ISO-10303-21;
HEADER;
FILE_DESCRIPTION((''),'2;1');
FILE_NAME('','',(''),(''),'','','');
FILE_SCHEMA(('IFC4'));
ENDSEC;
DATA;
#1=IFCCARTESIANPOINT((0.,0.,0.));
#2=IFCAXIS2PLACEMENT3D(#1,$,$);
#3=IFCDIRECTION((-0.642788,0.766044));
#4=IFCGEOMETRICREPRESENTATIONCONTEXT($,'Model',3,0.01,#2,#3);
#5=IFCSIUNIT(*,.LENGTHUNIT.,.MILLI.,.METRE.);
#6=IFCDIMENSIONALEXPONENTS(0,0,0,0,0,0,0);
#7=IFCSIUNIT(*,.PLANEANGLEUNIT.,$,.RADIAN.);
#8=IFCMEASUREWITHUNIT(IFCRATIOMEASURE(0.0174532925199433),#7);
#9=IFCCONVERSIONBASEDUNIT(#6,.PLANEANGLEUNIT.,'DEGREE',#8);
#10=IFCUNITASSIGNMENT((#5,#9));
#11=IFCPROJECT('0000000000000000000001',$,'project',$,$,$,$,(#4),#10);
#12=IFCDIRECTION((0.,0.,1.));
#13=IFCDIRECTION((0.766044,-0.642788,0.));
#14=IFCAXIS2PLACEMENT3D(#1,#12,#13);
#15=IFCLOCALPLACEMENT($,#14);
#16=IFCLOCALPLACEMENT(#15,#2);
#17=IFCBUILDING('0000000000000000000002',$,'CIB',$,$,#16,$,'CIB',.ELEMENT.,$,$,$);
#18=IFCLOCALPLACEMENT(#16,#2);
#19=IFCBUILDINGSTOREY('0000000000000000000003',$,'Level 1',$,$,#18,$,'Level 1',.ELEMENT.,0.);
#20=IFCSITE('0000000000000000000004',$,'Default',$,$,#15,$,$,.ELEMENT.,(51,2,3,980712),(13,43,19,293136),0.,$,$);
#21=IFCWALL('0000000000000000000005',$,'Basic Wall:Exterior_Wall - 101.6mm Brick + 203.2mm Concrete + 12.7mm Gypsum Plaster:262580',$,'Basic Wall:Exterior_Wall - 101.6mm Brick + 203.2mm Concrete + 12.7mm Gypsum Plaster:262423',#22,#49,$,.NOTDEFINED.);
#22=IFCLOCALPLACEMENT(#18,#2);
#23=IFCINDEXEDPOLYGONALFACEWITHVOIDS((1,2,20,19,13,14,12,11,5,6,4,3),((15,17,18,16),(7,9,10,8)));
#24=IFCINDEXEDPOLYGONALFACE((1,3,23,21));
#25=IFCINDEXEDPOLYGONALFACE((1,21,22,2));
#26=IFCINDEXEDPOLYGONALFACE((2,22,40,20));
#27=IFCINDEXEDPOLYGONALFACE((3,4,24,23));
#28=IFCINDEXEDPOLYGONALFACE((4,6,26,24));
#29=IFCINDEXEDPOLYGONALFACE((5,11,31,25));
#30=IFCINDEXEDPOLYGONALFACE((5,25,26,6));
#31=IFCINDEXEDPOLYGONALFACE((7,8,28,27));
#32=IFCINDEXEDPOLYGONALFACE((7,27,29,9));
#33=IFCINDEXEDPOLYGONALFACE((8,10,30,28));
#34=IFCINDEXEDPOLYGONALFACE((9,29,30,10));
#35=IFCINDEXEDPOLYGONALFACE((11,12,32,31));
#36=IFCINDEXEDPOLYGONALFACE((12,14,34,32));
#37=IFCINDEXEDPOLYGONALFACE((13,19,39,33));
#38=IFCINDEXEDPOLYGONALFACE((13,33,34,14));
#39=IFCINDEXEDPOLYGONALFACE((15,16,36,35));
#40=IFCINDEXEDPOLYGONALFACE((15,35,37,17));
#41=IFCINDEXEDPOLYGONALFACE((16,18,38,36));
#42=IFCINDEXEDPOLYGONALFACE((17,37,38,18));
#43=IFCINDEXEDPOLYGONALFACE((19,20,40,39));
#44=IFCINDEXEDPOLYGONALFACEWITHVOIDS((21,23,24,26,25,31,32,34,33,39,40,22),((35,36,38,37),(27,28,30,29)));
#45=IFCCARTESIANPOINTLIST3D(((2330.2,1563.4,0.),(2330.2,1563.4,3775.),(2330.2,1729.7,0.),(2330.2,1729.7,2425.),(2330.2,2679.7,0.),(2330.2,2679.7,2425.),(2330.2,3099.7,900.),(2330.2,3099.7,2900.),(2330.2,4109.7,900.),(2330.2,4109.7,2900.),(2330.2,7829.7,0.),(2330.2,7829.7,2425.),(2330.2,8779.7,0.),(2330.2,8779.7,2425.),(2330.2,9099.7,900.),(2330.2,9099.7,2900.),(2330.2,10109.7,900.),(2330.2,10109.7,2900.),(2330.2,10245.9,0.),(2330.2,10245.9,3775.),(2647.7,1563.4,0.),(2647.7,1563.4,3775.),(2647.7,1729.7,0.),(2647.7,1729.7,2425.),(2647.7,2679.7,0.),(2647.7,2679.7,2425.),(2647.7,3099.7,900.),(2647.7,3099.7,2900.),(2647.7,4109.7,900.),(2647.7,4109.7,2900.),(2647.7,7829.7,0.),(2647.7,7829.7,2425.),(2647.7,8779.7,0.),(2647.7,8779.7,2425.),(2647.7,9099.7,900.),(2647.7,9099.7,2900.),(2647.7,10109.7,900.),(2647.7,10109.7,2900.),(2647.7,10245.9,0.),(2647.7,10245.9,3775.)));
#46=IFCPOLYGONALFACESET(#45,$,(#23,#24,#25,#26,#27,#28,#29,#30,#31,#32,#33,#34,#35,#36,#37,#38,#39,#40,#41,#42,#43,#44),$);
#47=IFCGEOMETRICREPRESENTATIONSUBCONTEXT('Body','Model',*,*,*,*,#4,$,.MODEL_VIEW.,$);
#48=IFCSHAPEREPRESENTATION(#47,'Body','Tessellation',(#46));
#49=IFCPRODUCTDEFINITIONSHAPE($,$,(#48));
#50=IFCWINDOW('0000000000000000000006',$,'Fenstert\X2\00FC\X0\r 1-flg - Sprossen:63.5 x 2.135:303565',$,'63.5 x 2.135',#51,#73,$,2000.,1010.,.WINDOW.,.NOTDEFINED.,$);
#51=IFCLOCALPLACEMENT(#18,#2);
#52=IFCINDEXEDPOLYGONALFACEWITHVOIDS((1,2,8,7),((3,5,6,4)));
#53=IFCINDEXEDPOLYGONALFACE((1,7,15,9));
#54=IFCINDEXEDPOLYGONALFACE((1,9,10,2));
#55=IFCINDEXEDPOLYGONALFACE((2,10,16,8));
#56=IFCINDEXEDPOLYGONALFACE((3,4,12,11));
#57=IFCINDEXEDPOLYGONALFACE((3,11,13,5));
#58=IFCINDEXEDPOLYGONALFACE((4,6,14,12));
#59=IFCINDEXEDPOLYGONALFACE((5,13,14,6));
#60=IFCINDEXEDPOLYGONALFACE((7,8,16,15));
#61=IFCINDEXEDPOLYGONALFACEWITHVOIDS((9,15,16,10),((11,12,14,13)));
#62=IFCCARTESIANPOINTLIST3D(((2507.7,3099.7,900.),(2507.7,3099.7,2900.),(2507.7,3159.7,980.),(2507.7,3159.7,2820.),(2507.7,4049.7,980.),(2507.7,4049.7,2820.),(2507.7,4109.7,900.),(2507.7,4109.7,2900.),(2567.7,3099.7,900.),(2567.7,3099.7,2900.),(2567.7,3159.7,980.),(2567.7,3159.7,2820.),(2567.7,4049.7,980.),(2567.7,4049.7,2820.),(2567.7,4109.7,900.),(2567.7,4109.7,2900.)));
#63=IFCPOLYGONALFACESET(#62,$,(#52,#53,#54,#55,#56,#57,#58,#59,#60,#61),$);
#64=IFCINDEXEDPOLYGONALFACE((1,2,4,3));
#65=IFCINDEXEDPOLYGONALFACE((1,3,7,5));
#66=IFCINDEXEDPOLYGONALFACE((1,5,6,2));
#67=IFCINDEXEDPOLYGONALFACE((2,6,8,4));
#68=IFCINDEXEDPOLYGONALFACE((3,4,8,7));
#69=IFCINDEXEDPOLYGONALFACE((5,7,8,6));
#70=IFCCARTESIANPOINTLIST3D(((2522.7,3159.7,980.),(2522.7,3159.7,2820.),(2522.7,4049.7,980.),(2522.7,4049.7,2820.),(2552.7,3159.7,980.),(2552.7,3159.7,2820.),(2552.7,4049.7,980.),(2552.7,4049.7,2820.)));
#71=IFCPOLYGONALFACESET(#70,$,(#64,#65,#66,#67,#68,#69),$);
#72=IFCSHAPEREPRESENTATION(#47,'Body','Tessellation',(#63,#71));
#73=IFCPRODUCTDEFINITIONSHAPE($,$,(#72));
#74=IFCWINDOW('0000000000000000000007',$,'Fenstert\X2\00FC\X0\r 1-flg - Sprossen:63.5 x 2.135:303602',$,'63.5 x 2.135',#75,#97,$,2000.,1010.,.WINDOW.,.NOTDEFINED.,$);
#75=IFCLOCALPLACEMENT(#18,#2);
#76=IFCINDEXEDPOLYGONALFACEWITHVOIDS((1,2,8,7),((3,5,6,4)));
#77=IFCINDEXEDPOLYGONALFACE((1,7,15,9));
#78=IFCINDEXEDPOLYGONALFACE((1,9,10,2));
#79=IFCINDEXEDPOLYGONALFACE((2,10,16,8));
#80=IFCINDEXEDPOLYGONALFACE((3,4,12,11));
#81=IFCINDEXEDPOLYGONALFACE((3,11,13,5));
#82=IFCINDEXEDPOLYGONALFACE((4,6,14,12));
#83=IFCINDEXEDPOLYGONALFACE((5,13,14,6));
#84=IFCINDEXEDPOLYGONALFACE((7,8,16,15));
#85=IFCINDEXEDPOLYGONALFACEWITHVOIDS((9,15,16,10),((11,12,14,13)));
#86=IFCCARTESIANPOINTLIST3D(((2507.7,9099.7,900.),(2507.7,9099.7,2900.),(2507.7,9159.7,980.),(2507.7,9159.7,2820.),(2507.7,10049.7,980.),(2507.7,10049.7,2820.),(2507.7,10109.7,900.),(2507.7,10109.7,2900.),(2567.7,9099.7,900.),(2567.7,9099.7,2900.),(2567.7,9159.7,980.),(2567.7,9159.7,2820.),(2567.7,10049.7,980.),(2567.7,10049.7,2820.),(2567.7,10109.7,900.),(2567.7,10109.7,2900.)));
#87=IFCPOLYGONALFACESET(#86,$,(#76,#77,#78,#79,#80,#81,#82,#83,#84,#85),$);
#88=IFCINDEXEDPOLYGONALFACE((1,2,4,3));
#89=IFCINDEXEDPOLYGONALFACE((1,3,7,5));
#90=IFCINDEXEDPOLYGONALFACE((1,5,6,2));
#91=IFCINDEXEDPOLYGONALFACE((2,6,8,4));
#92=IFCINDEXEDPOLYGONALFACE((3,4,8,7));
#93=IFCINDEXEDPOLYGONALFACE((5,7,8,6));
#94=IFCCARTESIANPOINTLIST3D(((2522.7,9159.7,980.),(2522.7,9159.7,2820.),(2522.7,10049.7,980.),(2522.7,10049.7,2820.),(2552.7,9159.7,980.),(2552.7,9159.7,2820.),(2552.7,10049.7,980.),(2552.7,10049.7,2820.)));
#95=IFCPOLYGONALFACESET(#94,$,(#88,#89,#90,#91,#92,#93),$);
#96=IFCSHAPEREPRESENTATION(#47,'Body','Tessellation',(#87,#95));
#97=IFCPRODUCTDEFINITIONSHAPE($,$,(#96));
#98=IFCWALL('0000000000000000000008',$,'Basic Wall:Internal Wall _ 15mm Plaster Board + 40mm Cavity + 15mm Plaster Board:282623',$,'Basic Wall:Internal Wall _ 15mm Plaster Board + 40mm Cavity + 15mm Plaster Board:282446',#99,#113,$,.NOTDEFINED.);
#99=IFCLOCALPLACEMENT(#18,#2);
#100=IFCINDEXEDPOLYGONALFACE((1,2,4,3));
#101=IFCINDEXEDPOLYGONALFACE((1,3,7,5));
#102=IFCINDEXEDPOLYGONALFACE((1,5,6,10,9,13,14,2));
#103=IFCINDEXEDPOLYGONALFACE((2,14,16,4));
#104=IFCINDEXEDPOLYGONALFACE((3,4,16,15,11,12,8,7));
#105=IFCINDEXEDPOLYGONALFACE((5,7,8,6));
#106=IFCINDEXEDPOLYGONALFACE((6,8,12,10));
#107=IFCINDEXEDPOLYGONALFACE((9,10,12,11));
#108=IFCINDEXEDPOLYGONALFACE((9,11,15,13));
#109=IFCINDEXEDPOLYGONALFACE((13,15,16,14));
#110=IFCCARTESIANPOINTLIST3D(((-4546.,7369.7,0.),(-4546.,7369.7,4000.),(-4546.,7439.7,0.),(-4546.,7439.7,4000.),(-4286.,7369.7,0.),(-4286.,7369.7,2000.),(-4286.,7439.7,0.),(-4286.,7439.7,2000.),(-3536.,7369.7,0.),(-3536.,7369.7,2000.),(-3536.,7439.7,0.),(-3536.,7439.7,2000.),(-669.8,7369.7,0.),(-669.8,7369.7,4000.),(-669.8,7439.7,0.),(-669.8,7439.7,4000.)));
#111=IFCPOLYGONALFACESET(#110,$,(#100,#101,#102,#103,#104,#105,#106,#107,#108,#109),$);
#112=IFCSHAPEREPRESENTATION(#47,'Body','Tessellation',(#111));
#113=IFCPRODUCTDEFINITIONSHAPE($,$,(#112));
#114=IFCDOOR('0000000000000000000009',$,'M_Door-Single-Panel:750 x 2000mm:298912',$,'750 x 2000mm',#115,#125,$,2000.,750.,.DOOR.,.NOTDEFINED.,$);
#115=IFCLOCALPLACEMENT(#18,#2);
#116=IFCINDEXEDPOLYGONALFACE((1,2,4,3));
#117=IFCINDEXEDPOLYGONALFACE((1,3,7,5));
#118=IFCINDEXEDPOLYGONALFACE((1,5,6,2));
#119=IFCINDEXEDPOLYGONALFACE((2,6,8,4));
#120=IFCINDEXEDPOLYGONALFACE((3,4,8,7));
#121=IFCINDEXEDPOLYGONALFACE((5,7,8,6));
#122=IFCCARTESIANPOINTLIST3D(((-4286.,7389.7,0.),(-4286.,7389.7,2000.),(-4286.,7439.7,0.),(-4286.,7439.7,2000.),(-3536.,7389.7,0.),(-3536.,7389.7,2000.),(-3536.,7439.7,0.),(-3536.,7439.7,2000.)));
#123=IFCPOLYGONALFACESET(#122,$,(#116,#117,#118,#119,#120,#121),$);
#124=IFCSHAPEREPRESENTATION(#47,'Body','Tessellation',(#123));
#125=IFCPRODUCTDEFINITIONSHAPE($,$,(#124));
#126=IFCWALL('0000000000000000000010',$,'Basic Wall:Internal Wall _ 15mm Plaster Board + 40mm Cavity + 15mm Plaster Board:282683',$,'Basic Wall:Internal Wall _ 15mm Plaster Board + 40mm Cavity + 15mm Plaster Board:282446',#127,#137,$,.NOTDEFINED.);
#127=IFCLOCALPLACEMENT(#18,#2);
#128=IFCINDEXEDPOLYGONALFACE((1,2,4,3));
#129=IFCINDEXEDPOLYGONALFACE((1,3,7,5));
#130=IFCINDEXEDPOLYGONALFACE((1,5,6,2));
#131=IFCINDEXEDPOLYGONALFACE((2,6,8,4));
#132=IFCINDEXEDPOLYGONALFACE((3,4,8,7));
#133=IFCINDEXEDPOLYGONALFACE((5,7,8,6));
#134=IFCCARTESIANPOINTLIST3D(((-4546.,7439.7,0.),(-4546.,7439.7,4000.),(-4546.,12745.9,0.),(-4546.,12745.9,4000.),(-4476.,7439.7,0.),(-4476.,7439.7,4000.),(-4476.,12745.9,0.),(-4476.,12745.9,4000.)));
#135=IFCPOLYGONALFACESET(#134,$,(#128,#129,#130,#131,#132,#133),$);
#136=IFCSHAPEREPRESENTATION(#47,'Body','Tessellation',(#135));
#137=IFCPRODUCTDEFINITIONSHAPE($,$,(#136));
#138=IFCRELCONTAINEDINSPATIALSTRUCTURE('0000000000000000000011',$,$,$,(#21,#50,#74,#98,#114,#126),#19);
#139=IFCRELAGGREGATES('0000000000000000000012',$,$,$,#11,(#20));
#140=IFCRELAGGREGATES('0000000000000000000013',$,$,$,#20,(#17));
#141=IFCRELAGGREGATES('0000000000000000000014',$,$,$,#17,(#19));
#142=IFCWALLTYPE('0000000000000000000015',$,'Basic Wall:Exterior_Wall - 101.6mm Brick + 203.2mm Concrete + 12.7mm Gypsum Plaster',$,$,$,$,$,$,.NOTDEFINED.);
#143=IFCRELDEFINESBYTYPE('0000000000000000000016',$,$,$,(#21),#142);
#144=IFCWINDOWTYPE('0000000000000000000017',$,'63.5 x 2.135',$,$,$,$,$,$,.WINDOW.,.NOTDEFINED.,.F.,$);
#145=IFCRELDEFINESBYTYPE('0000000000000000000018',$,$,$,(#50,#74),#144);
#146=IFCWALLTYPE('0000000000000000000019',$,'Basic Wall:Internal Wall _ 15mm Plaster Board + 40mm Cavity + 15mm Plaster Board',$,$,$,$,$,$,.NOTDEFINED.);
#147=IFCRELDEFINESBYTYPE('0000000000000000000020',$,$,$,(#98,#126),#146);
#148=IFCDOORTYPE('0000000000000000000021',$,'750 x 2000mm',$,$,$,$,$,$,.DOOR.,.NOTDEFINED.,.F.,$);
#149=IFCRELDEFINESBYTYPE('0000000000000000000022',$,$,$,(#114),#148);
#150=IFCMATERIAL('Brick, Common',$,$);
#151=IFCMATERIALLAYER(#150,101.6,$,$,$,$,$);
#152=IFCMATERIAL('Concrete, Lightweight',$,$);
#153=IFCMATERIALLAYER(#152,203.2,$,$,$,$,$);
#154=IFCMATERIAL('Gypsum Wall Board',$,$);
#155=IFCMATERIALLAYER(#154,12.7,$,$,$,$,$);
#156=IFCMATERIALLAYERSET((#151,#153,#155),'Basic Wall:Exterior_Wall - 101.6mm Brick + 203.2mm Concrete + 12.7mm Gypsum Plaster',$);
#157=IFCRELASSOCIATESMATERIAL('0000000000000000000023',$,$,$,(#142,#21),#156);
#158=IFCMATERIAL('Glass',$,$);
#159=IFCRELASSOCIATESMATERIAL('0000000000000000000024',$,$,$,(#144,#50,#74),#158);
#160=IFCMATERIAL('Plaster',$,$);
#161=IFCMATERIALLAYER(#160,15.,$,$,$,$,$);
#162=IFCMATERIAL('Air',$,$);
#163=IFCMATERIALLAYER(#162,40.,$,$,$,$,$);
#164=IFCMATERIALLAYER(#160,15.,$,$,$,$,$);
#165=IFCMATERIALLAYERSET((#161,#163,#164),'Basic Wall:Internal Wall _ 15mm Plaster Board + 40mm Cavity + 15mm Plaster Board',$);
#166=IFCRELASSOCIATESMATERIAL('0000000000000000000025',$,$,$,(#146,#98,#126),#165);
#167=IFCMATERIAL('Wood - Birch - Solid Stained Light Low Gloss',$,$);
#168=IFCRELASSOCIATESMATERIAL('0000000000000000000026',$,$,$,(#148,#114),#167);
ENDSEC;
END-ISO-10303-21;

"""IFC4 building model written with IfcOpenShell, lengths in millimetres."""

from ifc_helpers import new_model, entity, si_unit, converted_unit, direction, frame, frame_2d, origin, origin_2d_with_axis, place, context, subcontext, project, spatial, polyline, rectangle, outline, extrude, clip, bounded_halfspace, source, transform, mapped, material, layer, layer_set, layer_usage, type_object, type_shapes, element, fill, save


model = new_model("IFC4")

# Units and contexts
model_context = context("Model", 3, precision=0.01, world=origin(), true_north=direction((-0.642788, 0.766044)))
body_context = subcontext(model_context, "Body", "Model", "MODEL_VIEW")
ifc_project = project(units=[si_unit("LENGTHUNIT", "METRE", prefix="MILLI"), converted_unit("PLANEANGLEUNIT", "DEGREE", entity("IfcRatioMeasure", 0.0174532925199433), si_unit("PLANEANGLEUNIT", "RADIAN"), dimensions=[0, 0, 0, 0, 0, 0, 0])], contexts=[model_context])

# Site, building, storey
site_placement = place(None, frame((0.0, 0.0, 0.0), z_axis=(0.0, 0.0, 1.0), x_axis=(0.766044, -0.642788, 0.0)))
site = spatial("IfcSite", under=ifc_project, at=site_placement, Name="Default", CompositionType="ELEMENT", RefLatitude=(51, 2, 3, 980712), RefLongitude=(13, 43, 19, 293136), RefElevation=0.0)
building_placement = place(site_placement, origin())
building = spatial("IfcBuilding", under=site, at=building_placement, Name="CIB", LongName="CIB", CompositionType="ELEMENT")
storey_placement = place(building_placement, origin())
storey = spatial("IfcBuildingStorey", under=building, at=storey_placement, Name="Level 1", LongName="Level 1", CompositionType="ELEMENT", Elevation=0.0)

# Shared definitions
ifc_material_1 = material(Name="Brick, Common")
ifc_layer_1 = layer(ifc_material_1, 101.6)
ifc_material_2 = material(Name="Concrete, Lightweight")
ifc_layer_2 = layer(ifc_material_2, 203.2)
ifc_material_3 = material(Name="Gypsum Wall Board")
ifc_layer_3 = layer(ifc_material_3, 12.7)
ifc_layer_set_1 = layer_set([ifc_layer_1, ifc_layer_2, ifc_layer_3], Name="Basic Wall:Exterior_Wall - 101.6mm Brick + 203.2mm Concrete + 12.7mm Gypsum Plaster")
wall_type_1 = type_object("IfcWallType", Name="Basic Wall:Exterior_Wall - 101.6mm Brick + 203.2mm Concrete + 12.7mm Gypsum Plaster", PredefinedType="NOTDEFINED", material=ifc_layer_set_1)
ifc_material_4 = material(Name="Glass")

# Wall, openings, windows
ifc_layer_usage_1 = layer_usage(ifc_layer_set_1, "AXIS2", "NEGATIVE", 158.8)
wall_1_placement = place(storey_placement, frame((2489.0, 10245.9, 0.0), z_axis=(0.0, 0.0, 1.0), x_axis=(0.0, -1.0, 0.0)))
wall_1 = element("IfcWall", 1, at=wall_1_placement, inside=storey, type_object=wall_type_1, material=ifc_layer_usage_1, Name="Basic Wall:Exterior_Wall - 101.6mm Brick + 203.2mm Concrete + 12.7mm Gypsum Plaster:262580", ObjectType="Basic Wall:Exterior_Wall - 101.6mm Brick + 203.2mm Concrete + 12.7mm Gypsum Plaster:262423", PredefinedType="NOTDEFINED", context=body_context, shape_type="Clipping", body=[
    clip(clip(extrude(rectangle(XDim=8682.5, YDim=317.5, at=frame_2d((4341.2, 0.0), x_axis=(-1.0, 0.0))), origin(), (0.0, 0.0, 1.0), 3775.0), bounded_halfspace(frame((0.0, -158.8, 3775.0), z_axis=(0.0, 0.0, -1.0), x_axis=(0.0, 1.0, 0.0)), True, frame((0.0, -158.8, 3775.0)), polyline([(0.0, 0.0), (2682.5, 0.0), (3000.0, 0.0), (3000.0, 317.5), (0.0, 317.5), (0.0, 0.0)]))), bounded_halfspace(frame((5682.5, -158.8, 3775.0), z_axis=(0.0, 0.0, -1.0), x_axis=(0.0, 1.0, 0.0)), True, frame((5682.5, -158.8, 3775.0)), polyline([(0.0, 0.0), (317.5, 0.0), (3000.0, 0.0), (3000.0, 317.5), (0.0, 317.5), (0.0, 0.0)]))),
])
opening_1_placement = place(wall_1_placement, frame((2416.2, 158.7, 0.0)))
element("IfcOpeningElement", 2, at=opening_1_placement, cuts=wall_1, ObjectType="Opening", PredefinedType="OPENING", context=body_context, shape_type="SweptSolid", body=[
    extrude(rectangle(XDim=2425.0, YDim=950.0, at=frame_2d((1212.5, 475.0), x_axis=(1.0, 0.0))), frame((0.0, 0.0, 0.0), z_axis=(0.0, -1.0, 0.0), x_axis=(0.0, 0.0, 1.0)), (0.0, 0.0, 1.0), 317.5),
])
opening_2_placement = place(wall_1_placement, frame((8516.2, 158.7, 0.0)))
element("IfcOpeningElement", 3, at=opening_2_placement, cuts=wall_1, ObjectType="Opening", PredefinedType="OPENING", context=body_context, shape_type="SweptSolid", body=[
    extrude(rectangle(XDim=2425.0, YDim=950.0, at=frame_2d((1212.5, 475.0), x_axis=(1.0, 0.0))), frame((0.0, 0.0, 0.0), z_axis=(0.0, -1.0, 0.0), x_axis=(0.0, 0.0, 1.0)), (0.0, 0.0, 1.0), 317.5),
])
opening_3_placement = place(wall_1_placement, frame((7146.2, 158.8, 900.0)))
opening_3 = element("IfcOpeningElement", 4, at=opening_3_placement, cuts=wall_1, ObjectType="Opening", PredefinedType="OPENING", context=body_context, shape_type="SweptSolid", body=[
    extrude(rectangle(XDim=2000.0, YDim=1010.0, at=frame_2d((1000.0, 505.0), x_axis=(1.0, 0.0))), frame((0.0, 0.0, 0.0), z_axis=(0.0, -1.0, 0.0), x_axis=(0.0, 0.0, 1.0)), (0.0, 0.0, 1.0), 317.5),
])
opening_4_placement = place(wall_1_placement, frame((1146.3, 158.8, 900.0)))
opening_4 = element("IfcOpeningElement", 5, at=opening_4_placement, cuts=wall_1, ObjectType="Opening", PredefinedType="OPENING", context=body_context, shape_type="SweptSolid", body=[
    extrude(rectangle(XDim=2000.0, YDim=1010.0, at=frame_2d((1000.0, 505.0), x_axis=(1.0, 0.0))), frame((0.0, 0.0, 0.0), z_axis=(0.0, -1.0, 0.0), x_axis=(0.0, 0.0, 1.0)), (0.0, 0.0, 1.0), 317.5),
])
window_type_1 = type_object("IfcWindowType", Name="63.5 x 2.135", ParameterTakesPrecedence=False, PartitioningType="NOTDEFINED", PredefinedType="WINDOW", material=ifc_material_4)
shared_shape_1 = source(origin(), body_context, "Body", "SweptSolid", [
    extrude(outline(polyline([(-1000.0, -505.0), (1000.0, -505.0), (1000.0, 505.0), (-1000.0, 505.0), (-1000.0, -505.0)]), holes=[polyline([(-920.0, -445.0), (-920.0, 445.0), (920.0, 445.0), (920.0, -445.0), (-920.0, -445.0)])]), frame((505.0, 177.5, 1000.0), z_axis=(0.0, 1.0, 0.0), x_axis=(0.0, 0.0, -1.0)), (0.0, 0.0, 1.0), 60.0),
    extrude(rectangle(XDim=30.0, YDim=890.0, at=origin_2d_with_axis()), frame((505.0, 207.5, 80.0), z_axis=(0.0, 0.0, 1.0), x_axis=(0.0, 1.0, 0.0)), (0.0, 0.0, 1.0), 1840.0),
])
type_shapes(window_type_1, [shared_shape_1])
window_1_placement = place(opening_3_placement, frame((-1010.0, -317.5, 0.0)))
window_1 = element("IfcWindow", 6, at=window_1_placement, inside=storey, type_object=window_type_1, material=ifc_material_4, Name="Fenstertür 1-flg - Sprossen:63.5 x 2.135:303565", ObjectType="63.5 x 2.135", OverallHeight=2000.0, OverallWidth=1010.0, PartitioningType="NOTDEFINED", PredefinedType="WINDOW", context=body_context, shape_type="MappedRepresentation", body=[
    mapped(shared_shape_1, transform((0.0, 0.0, 0.0), scale=1.0)),
])
fill(opening_3, window_1)
window_2_placement = place(opening_4_placement, frame((-1010.0, -317.5, 0.0)))
window_2 = element("IfcWindow", 7, at=window_2_placement, inside=storey, type_object=window_type_1, material=ifc_material_4, Name="Fenstertür 1-flg - Sprossen:63.5 x 2.135:303602", ObjectType="63.5 x 2.135", OverallHeight=2000.0, OverallWidth=1010.0, PartitioningType="NOTDEFINED", PredefinedType="WINDOW", context=body_context, shape_type="MappedRepresentation", body=[
    mapped(shared_shape_1, transform((0.0, 0.0, 0.0), scale=1.0)),
])
fill(opening_4, window_2)

# Wall, opening, door
ifc_material_5 = material(Name="Plaster")
ifc_layer_4 = layer(ifc_material_5, 15.0)
ifc_material_6 = material(Name="Air")
ifc_layer_5 = layer(ifc_material_6, 40.0)
ifc_layer_6 = layer(ifc_material_5, 15.0)
ifc_layer_set_2 = layer_set([ifc_layer_4, ifc_layer_5, ifc_layer_6], Name="Basic Wall:Internal Wall _ 15mm Plaster Board + 40mm Cavity + 15mm Plaster Board")
ifc_layer_usage_2 = layer_usage(ifc_layer_set_2, "AXIS2", "NEGATIVE", 35.0)
wall_type_2 = type_object("IfcWallType", Name="Basic Wall:Internal Wall _ 15mm Plaster Board + 40mm Cavity + 15mm Plaster Board", PredefinedType="NOTDEFINED", material=ifc_layer_set_2)
wall_2_placement = place(storey_placement, frame((-669.8, 7404.7, 0.0), z_axis=(0.0, 0.0, 1.0), x_axis=(-1.0, 0.0, 0.0)))
wall_2 = element("IfcWall", 8, at=wall_2_placement, inside=storey, type_object=wall_type_2, material=ifc_layer_usage_2, Name="Basic Wall:Internal Wall _ 15mm Plaster Board + 40mm Cavity + 15mm Plaster Board:282623", ObjectType="Basic Wall:Internal Wall _ 15mm Plaster Board + 40mm Cavity + 15mm Plaster Board:282446", PredefinedType="NOTDEFINED", context=body_context, shape_type="SweptSolid", body=[
    extrude(rectangle(XDim=3876.2, YDim=70.0, at=frame_2d((1938.1, 0.0), x_axis=(-1.0, 0.0))), origin(), (0.0, 0.0, 1.0), 4000.0),
])
opening_5_placement = place(wall_2_placement, frame((3616.2, 35.0, 0.0)))
opening_5 = element("IfcOpeningElement", 9, at=opening_5_placement, cuts=wall_2, ObjectType="Opening", PredefinedType="OPENING", context=body_context, shape_type="SweptSolid", body=[
    extrude(rectangle(XDim=750.0, YDim=2000.0, at=frame_2d((1000.0, 375.0), x_axis=(0.0, -1.0))), frame((0.0, 0.0, 0.0), z_axis=(0.0, -1.0, 0.0), x_axis=(0.0, 0.0, 1.0)), (0.0, 0.0, 1.0), 70.0),
])
ifc_material_7 = material(Name="Wood - Birch - Solid Stained Light Low Gloss")
door_type_1 = type_object("IfcDoorType", Name="750 x 2000mm", OperationType="NOTDEFINED", ParameterTakesPrecedence=False, PredefinedType="DOOR", material=ifc_material_7)
shared_shape_2 = source(origin(), body_context, "Body", "SweptSolid", [
    extrude(rectangle(XDim=750.0, YDim=50.0, at=origin_2d_with_axis()), frame((375.0, 45.0, 0.0)), (0.0, 0.0, 1.0), 2000.0),
])
type_shapes(door_type_1, [shared_shape_2])
door_1_placement = place(opening_5_placement, frame((0.0, 0.0, 0.0), z_axis=(0.0, 0.0, 1.0), x_axis=(-1.0, 0.0, 0.0)))
door_1 = element("IfcDoor", 10, at=door_1_placement, inside=storey, type_object=door_type_1, material=ifc_material_7, Name="M_Door-Single-Panel:750 x 2000mm:298912", ObjectType="750 x 2000mm", OperationType="NOTDEFINED", OverallHeight=2000.0, OverallWidth=750.0, PredefinedType="DOOR", context=body_context, shape_type="MappedRepresentation", body=[
    mapped(shared_shape_2, transform((0.0, 0.0, 0.0), scale=1.0)),
])
fill(opening_5, door_1)

# Wall
ifc_layer_usage_3 = layer_usage(ifc_layer_set_2, "AXIS2", "NEGATIVE", 35.0)
wall_3_placement = place(storey_placement, frame((-4511.0, 7439.7, 0.0), z_axis=(0.0, 0.0, 1.0), x_axis=(0.0, 1.0, 0.0)))
element("IfcWall", 11, at=wall_3_placement, inside=storey, type_object=wall_type_2, material=ifc_layer_usage_3, Name="Basic Wall:Internal Wall _ 15mm Plaster Board + 40mm Cavity + 15mm Plaster Board:282683", ObjectType="Basic Wall:Internal Wall _ 15mm Plaster Board + 40mm Cavity + 15mm Plaster Board:282446", PredefinedType="NOTDEFINED", context=body_context, shape_type="SweptSolid", body=[
    extrude(rectangle(XDim=5306.2, YDim=70.0, at=frame_2d((2653.1, 0.0), x_axis=(-1.0, 0.0))), origin(), (0.0, 0.0, 1.0), 4000.0),
])

save(model, "model.ifc")
